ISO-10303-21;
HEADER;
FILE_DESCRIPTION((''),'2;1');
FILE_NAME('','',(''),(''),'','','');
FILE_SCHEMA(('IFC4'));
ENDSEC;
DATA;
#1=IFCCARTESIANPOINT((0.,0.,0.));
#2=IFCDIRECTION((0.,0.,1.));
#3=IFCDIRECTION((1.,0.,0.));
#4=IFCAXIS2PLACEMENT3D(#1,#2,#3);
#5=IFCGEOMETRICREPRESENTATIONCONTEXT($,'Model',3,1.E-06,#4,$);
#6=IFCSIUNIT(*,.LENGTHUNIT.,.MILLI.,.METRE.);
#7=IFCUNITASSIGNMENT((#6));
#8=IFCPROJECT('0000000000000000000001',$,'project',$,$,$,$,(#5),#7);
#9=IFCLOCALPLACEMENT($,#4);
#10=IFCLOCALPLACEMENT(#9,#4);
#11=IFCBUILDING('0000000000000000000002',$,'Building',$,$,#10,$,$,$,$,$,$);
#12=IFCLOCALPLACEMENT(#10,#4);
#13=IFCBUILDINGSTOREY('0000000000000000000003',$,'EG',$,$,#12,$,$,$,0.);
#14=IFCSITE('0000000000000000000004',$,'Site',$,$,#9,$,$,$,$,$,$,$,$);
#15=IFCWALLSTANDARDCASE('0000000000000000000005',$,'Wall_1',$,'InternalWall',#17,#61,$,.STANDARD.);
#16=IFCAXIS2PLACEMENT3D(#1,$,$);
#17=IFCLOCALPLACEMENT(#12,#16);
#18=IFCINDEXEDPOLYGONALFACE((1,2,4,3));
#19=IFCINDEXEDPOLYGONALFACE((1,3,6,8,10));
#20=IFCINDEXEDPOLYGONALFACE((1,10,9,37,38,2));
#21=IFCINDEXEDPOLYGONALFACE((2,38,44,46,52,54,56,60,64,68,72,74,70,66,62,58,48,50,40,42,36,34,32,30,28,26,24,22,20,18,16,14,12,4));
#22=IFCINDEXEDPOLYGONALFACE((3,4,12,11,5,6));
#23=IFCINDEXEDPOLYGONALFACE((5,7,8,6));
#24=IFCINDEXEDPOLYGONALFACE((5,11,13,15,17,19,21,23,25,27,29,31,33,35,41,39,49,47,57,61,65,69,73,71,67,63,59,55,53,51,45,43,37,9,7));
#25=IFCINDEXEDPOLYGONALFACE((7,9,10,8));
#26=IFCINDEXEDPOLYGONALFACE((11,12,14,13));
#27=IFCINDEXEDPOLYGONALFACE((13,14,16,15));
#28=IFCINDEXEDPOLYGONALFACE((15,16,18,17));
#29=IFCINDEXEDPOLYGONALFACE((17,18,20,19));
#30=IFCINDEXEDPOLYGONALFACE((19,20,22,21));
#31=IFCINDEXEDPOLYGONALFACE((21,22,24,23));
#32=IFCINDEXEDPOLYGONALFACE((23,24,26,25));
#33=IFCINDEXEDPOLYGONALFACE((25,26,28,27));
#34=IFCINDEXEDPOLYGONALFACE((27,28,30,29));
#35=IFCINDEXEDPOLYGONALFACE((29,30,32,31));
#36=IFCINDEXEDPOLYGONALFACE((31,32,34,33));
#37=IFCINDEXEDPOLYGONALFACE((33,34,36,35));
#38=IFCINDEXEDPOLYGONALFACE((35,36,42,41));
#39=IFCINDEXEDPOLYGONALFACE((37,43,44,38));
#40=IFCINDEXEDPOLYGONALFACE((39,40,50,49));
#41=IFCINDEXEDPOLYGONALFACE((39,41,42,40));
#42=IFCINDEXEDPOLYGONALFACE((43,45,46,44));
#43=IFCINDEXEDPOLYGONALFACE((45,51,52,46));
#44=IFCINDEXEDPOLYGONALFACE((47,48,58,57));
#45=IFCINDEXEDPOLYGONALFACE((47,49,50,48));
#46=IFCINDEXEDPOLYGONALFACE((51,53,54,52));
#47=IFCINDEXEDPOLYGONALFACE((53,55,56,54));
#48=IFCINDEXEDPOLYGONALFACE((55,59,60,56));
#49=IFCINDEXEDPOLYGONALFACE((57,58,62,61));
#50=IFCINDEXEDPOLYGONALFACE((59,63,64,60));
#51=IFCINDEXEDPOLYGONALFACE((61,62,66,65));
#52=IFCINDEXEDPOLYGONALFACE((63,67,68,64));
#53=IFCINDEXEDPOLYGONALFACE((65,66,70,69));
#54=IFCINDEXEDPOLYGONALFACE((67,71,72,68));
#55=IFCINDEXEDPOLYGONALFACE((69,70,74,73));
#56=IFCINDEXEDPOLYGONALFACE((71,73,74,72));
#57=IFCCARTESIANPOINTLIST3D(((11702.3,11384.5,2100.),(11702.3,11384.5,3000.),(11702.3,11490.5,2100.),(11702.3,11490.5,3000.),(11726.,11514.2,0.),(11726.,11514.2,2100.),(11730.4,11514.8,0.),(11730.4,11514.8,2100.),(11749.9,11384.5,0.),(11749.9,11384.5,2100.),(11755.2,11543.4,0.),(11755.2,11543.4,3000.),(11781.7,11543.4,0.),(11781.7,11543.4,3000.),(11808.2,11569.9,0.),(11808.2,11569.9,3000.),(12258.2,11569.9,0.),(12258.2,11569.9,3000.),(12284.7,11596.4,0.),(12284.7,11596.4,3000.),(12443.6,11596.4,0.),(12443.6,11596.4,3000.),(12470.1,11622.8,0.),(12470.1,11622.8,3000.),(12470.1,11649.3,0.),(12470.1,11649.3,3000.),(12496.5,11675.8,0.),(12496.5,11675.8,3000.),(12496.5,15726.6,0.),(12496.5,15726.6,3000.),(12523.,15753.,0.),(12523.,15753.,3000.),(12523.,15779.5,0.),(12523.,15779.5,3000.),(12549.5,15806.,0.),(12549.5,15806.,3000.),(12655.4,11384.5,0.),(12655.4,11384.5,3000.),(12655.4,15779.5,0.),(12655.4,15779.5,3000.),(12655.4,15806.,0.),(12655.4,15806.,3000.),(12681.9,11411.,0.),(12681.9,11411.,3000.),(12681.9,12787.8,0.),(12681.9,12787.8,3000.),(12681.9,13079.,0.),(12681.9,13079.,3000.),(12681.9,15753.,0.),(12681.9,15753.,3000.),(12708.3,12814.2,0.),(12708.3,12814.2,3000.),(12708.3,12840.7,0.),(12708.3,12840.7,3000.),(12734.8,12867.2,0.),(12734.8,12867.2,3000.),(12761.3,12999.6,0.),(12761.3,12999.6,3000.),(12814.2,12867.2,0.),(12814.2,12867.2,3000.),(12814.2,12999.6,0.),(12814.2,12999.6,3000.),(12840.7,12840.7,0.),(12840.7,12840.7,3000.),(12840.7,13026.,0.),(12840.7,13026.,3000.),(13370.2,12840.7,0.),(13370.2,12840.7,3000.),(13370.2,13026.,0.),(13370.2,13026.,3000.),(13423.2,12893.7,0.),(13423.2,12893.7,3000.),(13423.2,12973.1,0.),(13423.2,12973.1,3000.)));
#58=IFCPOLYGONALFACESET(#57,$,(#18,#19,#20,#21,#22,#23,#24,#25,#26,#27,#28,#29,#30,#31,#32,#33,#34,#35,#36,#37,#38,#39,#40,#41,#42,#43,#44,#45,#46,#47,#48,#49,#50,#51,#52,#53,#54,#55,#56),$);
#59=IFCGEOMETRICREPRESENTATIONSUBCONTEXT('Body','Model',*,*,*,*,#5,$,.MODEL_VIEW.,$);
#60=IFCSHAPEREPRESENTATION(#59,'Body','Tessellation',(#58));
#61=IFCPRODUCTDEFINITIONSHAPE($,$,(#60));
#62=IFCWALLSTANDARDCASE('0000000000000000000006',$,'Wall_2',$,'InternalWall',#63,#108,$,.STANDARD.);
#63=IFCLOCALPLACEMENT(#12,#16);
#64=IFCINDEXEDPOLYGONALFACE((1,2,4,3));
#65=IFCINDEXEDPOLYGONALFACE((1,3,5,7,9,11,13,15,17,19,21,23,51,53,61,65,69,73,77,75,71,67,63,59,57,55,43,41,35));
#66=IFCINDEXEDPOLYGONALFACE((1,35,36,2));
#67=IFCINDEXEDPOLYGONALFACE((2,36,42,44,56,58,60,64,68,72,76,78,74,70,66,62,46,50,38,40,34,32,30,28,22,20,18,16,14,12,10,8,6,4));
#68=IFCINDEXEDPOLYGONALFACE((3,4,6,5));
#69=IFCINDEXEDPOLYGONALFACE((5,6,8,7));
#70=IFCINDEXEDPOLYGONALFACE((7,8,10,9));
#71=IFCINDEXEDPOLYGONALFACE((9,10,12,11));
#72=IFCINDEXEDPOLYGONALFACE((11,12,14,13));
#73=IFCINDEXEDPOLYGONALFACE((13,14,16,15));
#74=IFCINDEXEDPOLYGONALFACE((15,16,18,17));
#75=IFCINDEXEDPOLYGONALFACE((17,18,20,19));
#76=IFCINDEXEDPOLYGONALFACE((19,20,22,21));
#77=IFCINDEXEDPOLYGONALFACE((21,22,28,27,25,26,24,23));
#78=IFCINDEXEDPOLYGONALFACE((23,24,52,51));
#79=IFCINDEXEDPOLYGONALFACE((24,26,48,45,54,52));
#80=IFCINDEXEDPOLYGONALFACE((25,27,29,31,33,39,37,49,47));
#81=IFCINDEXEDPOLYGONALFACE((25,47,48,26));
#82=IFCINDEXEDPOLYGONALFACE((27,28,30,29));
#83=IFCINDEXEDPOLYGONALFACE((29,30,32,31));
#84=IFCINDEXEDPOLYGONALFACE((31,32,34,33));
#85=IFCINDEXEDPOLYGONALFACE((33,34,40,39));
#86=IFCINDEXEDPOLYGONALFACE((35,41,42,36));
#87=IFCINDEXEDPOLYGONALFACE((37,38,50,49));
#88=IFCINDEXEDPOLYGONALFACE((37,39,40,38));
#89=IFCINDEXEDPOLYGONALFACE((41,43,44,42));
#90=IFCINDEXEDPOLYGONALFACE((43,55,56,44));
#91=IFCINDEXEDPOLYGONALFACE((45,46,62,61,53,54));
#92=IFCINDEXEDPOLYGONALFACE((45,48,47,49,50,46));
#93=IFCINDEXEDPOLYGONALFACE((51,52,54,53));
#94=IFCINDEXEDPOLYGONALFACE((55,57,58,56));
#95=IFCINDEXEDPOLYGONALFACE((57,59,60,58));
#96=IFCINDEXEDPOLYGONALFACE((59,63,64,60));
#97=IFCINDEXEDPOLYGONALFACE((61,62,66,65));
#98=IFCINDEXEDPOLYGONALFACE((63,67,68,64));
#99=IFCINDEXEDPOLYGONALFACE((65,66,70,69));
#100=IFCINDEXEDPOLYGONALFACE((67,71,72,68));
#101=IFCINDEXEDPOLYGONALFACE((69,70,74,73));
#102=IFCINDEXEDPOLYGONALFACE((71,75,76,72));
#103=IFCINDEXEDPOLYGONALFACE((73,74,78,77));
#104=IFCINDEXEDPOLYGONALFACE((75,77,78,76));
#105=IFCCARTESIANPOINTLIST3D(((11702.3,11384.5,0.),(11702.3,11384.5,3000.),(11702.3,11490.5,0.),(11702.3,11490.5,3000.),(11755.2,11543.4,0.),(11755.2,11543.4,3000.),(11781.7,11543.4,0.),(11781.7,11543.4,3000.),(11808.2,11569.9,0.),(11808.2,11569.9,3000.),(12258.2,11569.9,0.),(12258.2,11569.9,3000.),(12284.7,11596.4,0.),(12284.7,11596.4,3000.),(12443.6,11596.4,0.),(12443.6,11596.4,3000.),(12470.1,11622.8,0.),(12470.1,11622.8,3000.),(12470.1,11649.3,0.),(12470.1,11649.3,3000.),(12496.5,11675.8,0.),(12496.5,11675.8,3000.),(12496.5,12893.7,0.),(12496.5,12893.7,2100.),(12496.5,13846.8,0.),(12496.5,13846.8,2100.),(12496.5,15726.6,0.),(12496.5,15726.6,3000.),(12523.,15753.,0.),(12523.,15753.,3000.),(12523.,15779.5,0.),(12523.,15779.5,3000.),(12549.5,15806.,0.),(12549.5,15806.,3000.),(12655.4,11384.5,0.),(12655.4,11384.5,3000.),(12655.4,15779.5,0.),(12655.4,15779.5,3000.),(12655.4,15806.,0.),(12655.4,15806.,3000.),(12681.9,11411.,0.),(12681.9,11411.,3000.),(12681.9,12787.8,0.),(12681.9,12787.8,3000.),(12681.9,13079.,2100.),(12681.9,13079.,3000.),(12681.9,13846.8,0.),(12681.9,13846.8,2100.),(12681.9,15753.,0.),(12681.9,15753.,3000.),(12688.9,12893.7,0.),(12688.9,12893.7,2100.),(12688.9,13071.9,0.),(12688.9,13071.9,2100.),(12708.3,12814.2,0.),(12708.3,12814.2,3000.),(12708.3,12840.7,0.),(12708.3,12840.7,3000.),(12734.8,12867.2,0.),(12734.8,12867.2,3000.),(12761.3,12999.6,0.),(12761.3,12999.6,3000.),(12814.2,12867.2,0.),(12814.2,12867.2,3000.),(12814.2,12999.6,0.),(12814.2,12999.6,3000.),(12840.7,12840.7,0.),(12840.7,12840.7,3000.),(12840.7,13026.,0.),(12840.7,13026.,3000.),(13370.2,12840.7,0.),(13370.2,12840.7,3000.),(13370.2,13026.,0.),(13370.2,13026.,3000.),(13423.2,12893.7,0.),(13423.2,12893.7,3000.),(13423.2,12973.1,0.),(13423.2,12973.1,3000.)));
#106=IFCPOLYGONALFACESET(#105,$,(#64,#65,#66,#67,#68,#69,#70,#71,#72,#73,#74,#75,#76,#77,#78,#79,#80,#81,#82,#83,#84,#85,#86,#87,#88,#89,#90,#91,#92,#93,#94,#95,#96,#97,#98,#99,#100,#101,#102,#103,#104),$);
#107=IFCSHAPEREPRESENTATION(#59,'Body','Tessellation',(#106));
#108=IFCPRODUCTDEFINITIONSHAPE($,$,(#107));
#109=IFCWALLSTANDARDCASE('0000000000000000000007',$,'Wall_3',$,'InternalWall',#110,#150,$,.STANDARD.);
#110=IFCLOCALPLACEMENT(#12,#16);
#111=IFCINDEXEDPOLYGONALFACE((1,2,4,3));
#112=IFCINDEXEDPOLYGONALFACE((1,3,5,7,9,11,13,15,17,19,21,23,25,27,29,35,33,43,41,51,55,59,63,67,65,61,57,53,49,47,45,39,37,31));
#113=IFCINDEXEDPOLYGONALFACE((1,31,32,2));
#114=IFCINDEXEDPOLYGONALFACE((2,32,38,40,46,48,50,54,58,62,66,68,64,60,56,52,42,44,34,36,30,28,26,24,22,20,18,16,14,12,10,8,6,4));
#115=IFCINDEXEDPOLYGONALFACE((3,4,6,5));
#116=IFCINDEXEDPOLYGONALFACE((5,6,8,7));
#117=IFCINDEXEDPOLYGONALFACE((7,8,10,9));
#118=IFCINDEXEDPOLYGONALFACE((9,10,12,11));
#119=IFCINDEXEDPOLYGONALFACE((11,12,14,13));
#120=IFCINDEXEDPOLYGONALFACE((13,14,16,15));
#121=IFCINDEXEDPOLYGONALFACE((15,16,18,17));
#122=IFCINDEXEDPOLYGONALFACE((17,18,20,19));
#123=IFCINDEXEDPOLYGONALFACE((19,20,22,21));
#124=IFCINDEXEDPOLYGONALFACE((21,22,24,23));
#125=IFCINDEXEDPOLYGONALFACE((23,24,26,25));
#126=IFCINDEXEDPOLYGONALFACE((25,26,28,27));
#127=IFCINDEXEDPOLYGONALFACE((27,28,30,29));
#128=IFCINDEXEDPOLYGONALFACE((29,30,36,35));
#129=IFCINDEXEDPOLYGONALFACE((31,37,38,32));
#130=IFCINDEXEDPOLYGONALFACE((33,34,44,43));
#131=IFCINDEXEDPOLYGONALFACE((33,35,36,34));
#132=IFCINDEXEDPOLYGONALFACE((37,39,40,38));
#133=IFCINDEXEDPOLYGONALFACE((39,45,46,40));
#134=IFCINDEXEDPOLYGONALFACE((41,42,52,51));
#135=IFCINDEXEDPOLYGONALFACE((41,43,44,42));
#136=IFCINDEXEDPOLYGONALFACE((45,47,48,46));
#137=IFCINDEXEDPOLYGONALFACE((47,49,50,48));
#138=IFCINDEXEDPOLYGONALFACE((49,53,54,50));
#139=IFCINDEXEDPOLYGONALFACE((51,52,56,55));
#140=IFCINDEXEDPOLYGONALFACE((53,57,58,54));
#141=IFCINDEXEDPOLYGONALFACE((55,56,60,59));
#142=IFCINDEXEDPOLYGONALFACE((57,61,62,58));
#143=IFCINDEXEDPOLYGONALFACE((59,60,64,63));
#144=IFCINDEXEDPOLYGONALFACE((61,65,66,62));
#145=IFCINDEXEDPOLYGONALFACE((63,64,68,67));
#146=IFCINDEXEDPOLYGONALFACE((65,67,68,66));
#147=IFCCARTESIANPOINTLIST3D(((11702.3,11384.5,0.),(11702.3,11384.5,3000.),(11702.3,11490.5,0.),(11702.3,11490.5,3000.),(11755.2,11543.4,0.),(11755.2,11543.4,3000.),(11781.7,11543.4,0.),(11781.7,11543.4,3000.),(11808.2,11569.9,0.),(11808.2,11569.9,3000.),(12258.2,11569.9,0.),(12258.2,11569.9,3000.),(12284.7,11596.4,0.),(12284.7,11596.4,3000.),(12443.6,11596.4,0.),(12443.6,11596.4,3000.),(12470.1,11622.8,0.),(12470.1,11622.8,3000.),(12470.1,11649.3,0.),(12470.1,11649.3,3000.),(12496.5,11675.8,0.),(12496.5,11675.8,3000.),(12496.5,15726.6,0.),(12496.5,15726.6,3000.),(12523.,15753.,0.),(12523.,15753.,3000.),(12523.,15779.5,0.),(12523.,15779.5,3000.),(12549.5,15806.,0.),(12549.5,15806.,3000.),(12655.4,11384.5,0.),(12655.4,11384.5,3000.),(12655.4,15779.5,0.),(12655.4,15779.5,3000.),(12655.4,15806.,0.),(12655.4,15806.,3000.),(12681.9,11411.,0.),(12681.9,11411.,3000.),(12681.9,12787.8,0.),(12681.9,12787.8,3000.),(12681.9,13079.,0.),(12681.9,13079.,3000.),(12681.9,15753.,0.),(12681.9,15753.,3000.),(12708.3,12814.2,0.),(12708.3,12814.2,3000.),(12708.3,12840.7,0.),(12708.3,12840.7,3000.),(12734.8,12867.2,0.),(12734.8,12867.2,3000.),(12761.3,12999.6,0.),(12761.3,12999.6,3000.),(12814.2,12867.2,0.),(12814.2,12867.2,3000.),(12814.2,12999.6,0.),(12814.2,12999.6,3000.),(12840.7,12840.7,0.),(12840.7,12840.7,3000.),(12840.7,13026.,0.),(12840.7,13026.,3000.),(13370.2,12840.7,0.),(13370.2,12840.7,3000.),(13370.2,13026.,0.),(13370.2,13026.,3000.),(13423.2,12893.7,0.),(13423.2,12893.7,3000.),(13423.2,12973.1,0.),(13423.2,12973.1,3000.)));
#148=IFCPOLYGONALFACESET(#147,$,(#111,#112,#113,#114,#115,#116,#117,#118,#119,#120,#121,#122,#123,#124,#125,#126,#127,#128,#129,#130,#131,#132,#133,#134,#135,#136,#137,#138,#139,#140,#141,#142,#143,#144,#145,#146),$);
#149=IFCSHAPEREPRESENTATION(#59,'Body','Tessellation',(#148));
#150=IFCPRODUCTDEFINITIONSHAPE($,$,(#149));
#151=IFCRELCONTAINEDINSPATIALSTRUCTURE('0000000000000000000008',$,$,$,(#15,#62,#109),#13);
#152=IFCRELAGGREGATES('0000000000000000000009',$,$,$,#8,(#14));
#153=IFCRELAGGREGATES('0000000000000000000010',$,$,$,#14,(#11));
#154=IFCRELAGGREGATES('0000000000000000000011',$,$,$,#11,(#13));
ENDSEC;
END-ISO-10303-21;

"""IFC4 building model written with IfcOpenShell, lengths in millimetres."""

from ifc_helpers import new_model, si_unit, frame, origin_with_axes, place, context, subcontext, project, spatial, polyline, rectangle, outline, extrude, element, save


model = new_model("IFC4")

# Units and contexts
model_context = context("Model", 3, precision=1e-06, world=origin_with_axes())
body_context = subcontext(model_context, "Body", "Model", "MODEL_VIEW")
ifc_project = project(units=[si_unit("LENGTHUNIT", "METRE", prefix="MILLI")], contexts=[model_context])

# Site, building, storey
site_placement = place(None, origin_with_axes())
site = spatial("IfcSite", under=ifc_project, at=site_placement, Name="Site")
building_placement = place(site_placement, origin_with_axes())
building = spatial("IfcBuilding", under=site, at=building_placement, Name="Building")
storey_placement = place(building_placement, origin_with_axes())
storey = spatial("IfcBuildingStorey", under=building, at=storey_placement, Name="EG", Elevation=0.0)

# Walls, openings
wall_1_placement = place(storey_placement, origin_with_axes())
wall_1 = element("IfcWallStandardCase", 1, at=wall_1_placement, inside=storey, Name="Wall_1", ObjectType="InternalWall", PredefinedType="STANDARD", context=body_context, shape_type="SweptSolid", body=[
    extrude(outline(polyline([(11702.3, 11384.5, 0.0), (11702.3, 11490.5, 0.0), (11755.2, 11543.4, 0.0), (11781.7, 11543.4, 0.0), (11808.2, 11569.9, 0.0), (12258.2, 11569.9, 0.0), (12284.7, 11596.4, 0.0), (12443.6, 11596.4, 0.0), (12470.1, 11622.8, 0.0), (12470.1, 11649.3, 0.0), (12496.5, 11675.8, 0.0), (12496.5, 15726.6, 0.0), (12523.0, 15753.0, 0.0), (12523.0, 15779.5, 0.0), (12549.5, 15806.0, 0.0), (12655.4, 15806.0, 0.0), (12655.4, 15779.5, 0.0), (12681.9, 15753.0, 0.0), (12681.9, 13079.0, 0.0), (12761.3, 12999.6, 0.0), (12814.2, 12999.6, 0.0), (12840.7, 13026.0, 0.0), (13370.2, 13026.0, 0.0), (13423.2, 12973.1, 0.0), (13423.2, 12893.7, 0.0), (13370.2, 12840.7, 0.0), (12840.7, 12840.7, 0.0), (12814.2, 12867.2, 0.0), (12734.8, 12867.2, 0.0), (12708.3, 12840.7, 0.0), (12708.3, 12814.2, 0.0), (12681.9, 12787.8, 0.0), (12681.9, 11411.0, 0.0), (12655.4, 11384.5, 0.0), (11702.3, 11384.5, 0.0)])), origin_with_axes(), (0.0, 0.0, 1.0), 3000.0),
])
opening_1_placement = place(wall_1_placement, origin_with_axes())
element("IfcOpeningElement", 2, at=opening_1_placement, inside=storey, cuts=wall_1, context=body_context, shape_type="SweptSolid", body=[
    extrude(rectangle(XDim=915.1, YDim=240.0), frame((11295.7, 11328.3, 0.0), z_axis=(0.0, 0.0, 1.0), x_axis=(-0.988936, -0.14834, 0.0)), (0.0, 0.0, 1.0), 2100.0),
])
wall_2_placement = place(storey_placement, origin_with_axes())
wall_2 = element("IfcWallStandardCase", 3, at=wall_2_placement, inside=storey, Name="Wall_2", ObjectType="InternalWall", PredefinedType="STANDARD", context=body_context, shape_type="SweptSolid", body=[
    extrude(outline(polyline([(11702.3, 11384.5, 0.0), (11702.3, 11490.5, 0.0), (11755.2, 11543.4, 0.0), (11781.7, 11543.4, 0.0), (11808.2, 11569.9, 0.0), (12258.2, 11569.9, 0.0), (12284.7, 11596.4, 0.0), (12443.6, 11596.4, 0.0), (12470.1, 11622.8, 0.0), (12470.1, 11649.3, 0.0), (12496.5, 11675.8, 0.0), (12496.5, 15726.6, 0.0), (12523.0, 15753.0, 0.0), (12523.0, 15779.5, 0.0), (12549.5, 15806.0, 0.0), (12655.4, 15806.0, 0.0), (12655.4, 15779.5, 0.0), (12681.9, 15753.0, 0.0), (12681.9, 13079.0, 0.0), (12761.3, 12999.6, 0.0), (12814.2, 12999.6, 0.0), (12840.7, 13026.0, 0.0), (13370.2, 13026.0, 0.0), (13423.2, 12973.1, 0.0), (13423.2, 12893.7, 0.0), (13370.2, 12840.7, 0.0), (12840.7, 12840.7, 0.0), (12814.2, 12867.2, 0.0), (12734.8, 12867.2, 0.0), (12708.3, 12840.7, 0.0), (12708.3, 12814.2, 0.0), (12681.9, 12787.8, 0.0), (12681.9, 11411.0, 0.0), (12655.4, 11384.5, 0.0), (11702.3, 11384.5, 0.0)])), origin_with_axes(), (0.0, 0.0, 1.0), 3000.0),
])
opening_2_placement = place(wall_2_placement, origin_with_axes())
element("IfcOpeningElement", 4, at=opening_2_placement, inside=storey, cuts=wall_2, context=body_context, shape_type="SweptSolid", body=[
    extrude(rectangle(XDim=953.1, YDim=240.0), frame((12568.9, 13370.2, 0.0), z_axis=(0.0, 0.0, 1.0), x_axis=(0.0, -1.0, 0.0)), (0.0, 0.0, 1.0), 2100.0),
])

# Wall
for number, where, z_axis, x_axis, name in (
    (5, (0.0, 0.0, 0.0), (0.0, 0.0, 1.0), (1.0, 0.0, 0.0), "Wall_3"),
):
    element("IfcWallStandardCase", number, at=place(storey_placement, frame(where, z_axis=z_axis, x_axis=x_axis)), inside=storey, Name=name, ObjectType="InternalWall", PredefinedType="STANDARD", context=body_context, shape_type="SweptSolid", body=[
        extrude(outline(polyline([(11702.3, 11384.5, 0.0), (11702.3, 11490.5, 0.0), (11755.2, 11543.4, 0.0), (11781.7, 11543.4, 0.0), (11808.2, 11569.9, 0.0), (12258.2, 11569.9, 0.0), (12284.7, 11596.4, 0.0), (12443.6, 11596.4, 0.0), (12470.1, 11622.8, 0.0), (12470.1, 11649.3, 0.0), (12496.5, 11675.8, 0.0), (12496.5, 15726.6, 0.0), (12523.0, 15753.0, 0.0), (12523.0, 15779.5, 0.0), (12549.5, 15806.0, 0.0), (12655.4, 15806.0, 0.0), (12655.4, 15779.5, 0.0), (12681.9, 15753.0, 0.0), (12681.9, 13079.0, 0.0), (12761.3, 12999.6, 0.0), (12814.2, 12999.6, 0.0), (12840.7, 13026.0, 0.0), (13370.2, 13026.0, 0.0), (13423.2, 12973.1, 0.0), (13423.2, 12893.7, 0.0), (13370.2, 12840.7, 0.0), (12840.7, 12840.7, 0.0), (12814.2, 12867.2, 0.0), (12734.8, 12867.2, 0.0), (12708.3, 12840.7, 0.0), (12708.3, 12814.2, 0.0), (12681.9, 12787.8, 0.0), (12681.9, 11411.0, 0.0), (12655.4, 11384.5, 0.0), (11702.3, 11384.5, 0.0)])), origin_with_axes(), (0.0, 0.0, 1.0), 3000.0),
    ])

save(model, "model.ifc")
